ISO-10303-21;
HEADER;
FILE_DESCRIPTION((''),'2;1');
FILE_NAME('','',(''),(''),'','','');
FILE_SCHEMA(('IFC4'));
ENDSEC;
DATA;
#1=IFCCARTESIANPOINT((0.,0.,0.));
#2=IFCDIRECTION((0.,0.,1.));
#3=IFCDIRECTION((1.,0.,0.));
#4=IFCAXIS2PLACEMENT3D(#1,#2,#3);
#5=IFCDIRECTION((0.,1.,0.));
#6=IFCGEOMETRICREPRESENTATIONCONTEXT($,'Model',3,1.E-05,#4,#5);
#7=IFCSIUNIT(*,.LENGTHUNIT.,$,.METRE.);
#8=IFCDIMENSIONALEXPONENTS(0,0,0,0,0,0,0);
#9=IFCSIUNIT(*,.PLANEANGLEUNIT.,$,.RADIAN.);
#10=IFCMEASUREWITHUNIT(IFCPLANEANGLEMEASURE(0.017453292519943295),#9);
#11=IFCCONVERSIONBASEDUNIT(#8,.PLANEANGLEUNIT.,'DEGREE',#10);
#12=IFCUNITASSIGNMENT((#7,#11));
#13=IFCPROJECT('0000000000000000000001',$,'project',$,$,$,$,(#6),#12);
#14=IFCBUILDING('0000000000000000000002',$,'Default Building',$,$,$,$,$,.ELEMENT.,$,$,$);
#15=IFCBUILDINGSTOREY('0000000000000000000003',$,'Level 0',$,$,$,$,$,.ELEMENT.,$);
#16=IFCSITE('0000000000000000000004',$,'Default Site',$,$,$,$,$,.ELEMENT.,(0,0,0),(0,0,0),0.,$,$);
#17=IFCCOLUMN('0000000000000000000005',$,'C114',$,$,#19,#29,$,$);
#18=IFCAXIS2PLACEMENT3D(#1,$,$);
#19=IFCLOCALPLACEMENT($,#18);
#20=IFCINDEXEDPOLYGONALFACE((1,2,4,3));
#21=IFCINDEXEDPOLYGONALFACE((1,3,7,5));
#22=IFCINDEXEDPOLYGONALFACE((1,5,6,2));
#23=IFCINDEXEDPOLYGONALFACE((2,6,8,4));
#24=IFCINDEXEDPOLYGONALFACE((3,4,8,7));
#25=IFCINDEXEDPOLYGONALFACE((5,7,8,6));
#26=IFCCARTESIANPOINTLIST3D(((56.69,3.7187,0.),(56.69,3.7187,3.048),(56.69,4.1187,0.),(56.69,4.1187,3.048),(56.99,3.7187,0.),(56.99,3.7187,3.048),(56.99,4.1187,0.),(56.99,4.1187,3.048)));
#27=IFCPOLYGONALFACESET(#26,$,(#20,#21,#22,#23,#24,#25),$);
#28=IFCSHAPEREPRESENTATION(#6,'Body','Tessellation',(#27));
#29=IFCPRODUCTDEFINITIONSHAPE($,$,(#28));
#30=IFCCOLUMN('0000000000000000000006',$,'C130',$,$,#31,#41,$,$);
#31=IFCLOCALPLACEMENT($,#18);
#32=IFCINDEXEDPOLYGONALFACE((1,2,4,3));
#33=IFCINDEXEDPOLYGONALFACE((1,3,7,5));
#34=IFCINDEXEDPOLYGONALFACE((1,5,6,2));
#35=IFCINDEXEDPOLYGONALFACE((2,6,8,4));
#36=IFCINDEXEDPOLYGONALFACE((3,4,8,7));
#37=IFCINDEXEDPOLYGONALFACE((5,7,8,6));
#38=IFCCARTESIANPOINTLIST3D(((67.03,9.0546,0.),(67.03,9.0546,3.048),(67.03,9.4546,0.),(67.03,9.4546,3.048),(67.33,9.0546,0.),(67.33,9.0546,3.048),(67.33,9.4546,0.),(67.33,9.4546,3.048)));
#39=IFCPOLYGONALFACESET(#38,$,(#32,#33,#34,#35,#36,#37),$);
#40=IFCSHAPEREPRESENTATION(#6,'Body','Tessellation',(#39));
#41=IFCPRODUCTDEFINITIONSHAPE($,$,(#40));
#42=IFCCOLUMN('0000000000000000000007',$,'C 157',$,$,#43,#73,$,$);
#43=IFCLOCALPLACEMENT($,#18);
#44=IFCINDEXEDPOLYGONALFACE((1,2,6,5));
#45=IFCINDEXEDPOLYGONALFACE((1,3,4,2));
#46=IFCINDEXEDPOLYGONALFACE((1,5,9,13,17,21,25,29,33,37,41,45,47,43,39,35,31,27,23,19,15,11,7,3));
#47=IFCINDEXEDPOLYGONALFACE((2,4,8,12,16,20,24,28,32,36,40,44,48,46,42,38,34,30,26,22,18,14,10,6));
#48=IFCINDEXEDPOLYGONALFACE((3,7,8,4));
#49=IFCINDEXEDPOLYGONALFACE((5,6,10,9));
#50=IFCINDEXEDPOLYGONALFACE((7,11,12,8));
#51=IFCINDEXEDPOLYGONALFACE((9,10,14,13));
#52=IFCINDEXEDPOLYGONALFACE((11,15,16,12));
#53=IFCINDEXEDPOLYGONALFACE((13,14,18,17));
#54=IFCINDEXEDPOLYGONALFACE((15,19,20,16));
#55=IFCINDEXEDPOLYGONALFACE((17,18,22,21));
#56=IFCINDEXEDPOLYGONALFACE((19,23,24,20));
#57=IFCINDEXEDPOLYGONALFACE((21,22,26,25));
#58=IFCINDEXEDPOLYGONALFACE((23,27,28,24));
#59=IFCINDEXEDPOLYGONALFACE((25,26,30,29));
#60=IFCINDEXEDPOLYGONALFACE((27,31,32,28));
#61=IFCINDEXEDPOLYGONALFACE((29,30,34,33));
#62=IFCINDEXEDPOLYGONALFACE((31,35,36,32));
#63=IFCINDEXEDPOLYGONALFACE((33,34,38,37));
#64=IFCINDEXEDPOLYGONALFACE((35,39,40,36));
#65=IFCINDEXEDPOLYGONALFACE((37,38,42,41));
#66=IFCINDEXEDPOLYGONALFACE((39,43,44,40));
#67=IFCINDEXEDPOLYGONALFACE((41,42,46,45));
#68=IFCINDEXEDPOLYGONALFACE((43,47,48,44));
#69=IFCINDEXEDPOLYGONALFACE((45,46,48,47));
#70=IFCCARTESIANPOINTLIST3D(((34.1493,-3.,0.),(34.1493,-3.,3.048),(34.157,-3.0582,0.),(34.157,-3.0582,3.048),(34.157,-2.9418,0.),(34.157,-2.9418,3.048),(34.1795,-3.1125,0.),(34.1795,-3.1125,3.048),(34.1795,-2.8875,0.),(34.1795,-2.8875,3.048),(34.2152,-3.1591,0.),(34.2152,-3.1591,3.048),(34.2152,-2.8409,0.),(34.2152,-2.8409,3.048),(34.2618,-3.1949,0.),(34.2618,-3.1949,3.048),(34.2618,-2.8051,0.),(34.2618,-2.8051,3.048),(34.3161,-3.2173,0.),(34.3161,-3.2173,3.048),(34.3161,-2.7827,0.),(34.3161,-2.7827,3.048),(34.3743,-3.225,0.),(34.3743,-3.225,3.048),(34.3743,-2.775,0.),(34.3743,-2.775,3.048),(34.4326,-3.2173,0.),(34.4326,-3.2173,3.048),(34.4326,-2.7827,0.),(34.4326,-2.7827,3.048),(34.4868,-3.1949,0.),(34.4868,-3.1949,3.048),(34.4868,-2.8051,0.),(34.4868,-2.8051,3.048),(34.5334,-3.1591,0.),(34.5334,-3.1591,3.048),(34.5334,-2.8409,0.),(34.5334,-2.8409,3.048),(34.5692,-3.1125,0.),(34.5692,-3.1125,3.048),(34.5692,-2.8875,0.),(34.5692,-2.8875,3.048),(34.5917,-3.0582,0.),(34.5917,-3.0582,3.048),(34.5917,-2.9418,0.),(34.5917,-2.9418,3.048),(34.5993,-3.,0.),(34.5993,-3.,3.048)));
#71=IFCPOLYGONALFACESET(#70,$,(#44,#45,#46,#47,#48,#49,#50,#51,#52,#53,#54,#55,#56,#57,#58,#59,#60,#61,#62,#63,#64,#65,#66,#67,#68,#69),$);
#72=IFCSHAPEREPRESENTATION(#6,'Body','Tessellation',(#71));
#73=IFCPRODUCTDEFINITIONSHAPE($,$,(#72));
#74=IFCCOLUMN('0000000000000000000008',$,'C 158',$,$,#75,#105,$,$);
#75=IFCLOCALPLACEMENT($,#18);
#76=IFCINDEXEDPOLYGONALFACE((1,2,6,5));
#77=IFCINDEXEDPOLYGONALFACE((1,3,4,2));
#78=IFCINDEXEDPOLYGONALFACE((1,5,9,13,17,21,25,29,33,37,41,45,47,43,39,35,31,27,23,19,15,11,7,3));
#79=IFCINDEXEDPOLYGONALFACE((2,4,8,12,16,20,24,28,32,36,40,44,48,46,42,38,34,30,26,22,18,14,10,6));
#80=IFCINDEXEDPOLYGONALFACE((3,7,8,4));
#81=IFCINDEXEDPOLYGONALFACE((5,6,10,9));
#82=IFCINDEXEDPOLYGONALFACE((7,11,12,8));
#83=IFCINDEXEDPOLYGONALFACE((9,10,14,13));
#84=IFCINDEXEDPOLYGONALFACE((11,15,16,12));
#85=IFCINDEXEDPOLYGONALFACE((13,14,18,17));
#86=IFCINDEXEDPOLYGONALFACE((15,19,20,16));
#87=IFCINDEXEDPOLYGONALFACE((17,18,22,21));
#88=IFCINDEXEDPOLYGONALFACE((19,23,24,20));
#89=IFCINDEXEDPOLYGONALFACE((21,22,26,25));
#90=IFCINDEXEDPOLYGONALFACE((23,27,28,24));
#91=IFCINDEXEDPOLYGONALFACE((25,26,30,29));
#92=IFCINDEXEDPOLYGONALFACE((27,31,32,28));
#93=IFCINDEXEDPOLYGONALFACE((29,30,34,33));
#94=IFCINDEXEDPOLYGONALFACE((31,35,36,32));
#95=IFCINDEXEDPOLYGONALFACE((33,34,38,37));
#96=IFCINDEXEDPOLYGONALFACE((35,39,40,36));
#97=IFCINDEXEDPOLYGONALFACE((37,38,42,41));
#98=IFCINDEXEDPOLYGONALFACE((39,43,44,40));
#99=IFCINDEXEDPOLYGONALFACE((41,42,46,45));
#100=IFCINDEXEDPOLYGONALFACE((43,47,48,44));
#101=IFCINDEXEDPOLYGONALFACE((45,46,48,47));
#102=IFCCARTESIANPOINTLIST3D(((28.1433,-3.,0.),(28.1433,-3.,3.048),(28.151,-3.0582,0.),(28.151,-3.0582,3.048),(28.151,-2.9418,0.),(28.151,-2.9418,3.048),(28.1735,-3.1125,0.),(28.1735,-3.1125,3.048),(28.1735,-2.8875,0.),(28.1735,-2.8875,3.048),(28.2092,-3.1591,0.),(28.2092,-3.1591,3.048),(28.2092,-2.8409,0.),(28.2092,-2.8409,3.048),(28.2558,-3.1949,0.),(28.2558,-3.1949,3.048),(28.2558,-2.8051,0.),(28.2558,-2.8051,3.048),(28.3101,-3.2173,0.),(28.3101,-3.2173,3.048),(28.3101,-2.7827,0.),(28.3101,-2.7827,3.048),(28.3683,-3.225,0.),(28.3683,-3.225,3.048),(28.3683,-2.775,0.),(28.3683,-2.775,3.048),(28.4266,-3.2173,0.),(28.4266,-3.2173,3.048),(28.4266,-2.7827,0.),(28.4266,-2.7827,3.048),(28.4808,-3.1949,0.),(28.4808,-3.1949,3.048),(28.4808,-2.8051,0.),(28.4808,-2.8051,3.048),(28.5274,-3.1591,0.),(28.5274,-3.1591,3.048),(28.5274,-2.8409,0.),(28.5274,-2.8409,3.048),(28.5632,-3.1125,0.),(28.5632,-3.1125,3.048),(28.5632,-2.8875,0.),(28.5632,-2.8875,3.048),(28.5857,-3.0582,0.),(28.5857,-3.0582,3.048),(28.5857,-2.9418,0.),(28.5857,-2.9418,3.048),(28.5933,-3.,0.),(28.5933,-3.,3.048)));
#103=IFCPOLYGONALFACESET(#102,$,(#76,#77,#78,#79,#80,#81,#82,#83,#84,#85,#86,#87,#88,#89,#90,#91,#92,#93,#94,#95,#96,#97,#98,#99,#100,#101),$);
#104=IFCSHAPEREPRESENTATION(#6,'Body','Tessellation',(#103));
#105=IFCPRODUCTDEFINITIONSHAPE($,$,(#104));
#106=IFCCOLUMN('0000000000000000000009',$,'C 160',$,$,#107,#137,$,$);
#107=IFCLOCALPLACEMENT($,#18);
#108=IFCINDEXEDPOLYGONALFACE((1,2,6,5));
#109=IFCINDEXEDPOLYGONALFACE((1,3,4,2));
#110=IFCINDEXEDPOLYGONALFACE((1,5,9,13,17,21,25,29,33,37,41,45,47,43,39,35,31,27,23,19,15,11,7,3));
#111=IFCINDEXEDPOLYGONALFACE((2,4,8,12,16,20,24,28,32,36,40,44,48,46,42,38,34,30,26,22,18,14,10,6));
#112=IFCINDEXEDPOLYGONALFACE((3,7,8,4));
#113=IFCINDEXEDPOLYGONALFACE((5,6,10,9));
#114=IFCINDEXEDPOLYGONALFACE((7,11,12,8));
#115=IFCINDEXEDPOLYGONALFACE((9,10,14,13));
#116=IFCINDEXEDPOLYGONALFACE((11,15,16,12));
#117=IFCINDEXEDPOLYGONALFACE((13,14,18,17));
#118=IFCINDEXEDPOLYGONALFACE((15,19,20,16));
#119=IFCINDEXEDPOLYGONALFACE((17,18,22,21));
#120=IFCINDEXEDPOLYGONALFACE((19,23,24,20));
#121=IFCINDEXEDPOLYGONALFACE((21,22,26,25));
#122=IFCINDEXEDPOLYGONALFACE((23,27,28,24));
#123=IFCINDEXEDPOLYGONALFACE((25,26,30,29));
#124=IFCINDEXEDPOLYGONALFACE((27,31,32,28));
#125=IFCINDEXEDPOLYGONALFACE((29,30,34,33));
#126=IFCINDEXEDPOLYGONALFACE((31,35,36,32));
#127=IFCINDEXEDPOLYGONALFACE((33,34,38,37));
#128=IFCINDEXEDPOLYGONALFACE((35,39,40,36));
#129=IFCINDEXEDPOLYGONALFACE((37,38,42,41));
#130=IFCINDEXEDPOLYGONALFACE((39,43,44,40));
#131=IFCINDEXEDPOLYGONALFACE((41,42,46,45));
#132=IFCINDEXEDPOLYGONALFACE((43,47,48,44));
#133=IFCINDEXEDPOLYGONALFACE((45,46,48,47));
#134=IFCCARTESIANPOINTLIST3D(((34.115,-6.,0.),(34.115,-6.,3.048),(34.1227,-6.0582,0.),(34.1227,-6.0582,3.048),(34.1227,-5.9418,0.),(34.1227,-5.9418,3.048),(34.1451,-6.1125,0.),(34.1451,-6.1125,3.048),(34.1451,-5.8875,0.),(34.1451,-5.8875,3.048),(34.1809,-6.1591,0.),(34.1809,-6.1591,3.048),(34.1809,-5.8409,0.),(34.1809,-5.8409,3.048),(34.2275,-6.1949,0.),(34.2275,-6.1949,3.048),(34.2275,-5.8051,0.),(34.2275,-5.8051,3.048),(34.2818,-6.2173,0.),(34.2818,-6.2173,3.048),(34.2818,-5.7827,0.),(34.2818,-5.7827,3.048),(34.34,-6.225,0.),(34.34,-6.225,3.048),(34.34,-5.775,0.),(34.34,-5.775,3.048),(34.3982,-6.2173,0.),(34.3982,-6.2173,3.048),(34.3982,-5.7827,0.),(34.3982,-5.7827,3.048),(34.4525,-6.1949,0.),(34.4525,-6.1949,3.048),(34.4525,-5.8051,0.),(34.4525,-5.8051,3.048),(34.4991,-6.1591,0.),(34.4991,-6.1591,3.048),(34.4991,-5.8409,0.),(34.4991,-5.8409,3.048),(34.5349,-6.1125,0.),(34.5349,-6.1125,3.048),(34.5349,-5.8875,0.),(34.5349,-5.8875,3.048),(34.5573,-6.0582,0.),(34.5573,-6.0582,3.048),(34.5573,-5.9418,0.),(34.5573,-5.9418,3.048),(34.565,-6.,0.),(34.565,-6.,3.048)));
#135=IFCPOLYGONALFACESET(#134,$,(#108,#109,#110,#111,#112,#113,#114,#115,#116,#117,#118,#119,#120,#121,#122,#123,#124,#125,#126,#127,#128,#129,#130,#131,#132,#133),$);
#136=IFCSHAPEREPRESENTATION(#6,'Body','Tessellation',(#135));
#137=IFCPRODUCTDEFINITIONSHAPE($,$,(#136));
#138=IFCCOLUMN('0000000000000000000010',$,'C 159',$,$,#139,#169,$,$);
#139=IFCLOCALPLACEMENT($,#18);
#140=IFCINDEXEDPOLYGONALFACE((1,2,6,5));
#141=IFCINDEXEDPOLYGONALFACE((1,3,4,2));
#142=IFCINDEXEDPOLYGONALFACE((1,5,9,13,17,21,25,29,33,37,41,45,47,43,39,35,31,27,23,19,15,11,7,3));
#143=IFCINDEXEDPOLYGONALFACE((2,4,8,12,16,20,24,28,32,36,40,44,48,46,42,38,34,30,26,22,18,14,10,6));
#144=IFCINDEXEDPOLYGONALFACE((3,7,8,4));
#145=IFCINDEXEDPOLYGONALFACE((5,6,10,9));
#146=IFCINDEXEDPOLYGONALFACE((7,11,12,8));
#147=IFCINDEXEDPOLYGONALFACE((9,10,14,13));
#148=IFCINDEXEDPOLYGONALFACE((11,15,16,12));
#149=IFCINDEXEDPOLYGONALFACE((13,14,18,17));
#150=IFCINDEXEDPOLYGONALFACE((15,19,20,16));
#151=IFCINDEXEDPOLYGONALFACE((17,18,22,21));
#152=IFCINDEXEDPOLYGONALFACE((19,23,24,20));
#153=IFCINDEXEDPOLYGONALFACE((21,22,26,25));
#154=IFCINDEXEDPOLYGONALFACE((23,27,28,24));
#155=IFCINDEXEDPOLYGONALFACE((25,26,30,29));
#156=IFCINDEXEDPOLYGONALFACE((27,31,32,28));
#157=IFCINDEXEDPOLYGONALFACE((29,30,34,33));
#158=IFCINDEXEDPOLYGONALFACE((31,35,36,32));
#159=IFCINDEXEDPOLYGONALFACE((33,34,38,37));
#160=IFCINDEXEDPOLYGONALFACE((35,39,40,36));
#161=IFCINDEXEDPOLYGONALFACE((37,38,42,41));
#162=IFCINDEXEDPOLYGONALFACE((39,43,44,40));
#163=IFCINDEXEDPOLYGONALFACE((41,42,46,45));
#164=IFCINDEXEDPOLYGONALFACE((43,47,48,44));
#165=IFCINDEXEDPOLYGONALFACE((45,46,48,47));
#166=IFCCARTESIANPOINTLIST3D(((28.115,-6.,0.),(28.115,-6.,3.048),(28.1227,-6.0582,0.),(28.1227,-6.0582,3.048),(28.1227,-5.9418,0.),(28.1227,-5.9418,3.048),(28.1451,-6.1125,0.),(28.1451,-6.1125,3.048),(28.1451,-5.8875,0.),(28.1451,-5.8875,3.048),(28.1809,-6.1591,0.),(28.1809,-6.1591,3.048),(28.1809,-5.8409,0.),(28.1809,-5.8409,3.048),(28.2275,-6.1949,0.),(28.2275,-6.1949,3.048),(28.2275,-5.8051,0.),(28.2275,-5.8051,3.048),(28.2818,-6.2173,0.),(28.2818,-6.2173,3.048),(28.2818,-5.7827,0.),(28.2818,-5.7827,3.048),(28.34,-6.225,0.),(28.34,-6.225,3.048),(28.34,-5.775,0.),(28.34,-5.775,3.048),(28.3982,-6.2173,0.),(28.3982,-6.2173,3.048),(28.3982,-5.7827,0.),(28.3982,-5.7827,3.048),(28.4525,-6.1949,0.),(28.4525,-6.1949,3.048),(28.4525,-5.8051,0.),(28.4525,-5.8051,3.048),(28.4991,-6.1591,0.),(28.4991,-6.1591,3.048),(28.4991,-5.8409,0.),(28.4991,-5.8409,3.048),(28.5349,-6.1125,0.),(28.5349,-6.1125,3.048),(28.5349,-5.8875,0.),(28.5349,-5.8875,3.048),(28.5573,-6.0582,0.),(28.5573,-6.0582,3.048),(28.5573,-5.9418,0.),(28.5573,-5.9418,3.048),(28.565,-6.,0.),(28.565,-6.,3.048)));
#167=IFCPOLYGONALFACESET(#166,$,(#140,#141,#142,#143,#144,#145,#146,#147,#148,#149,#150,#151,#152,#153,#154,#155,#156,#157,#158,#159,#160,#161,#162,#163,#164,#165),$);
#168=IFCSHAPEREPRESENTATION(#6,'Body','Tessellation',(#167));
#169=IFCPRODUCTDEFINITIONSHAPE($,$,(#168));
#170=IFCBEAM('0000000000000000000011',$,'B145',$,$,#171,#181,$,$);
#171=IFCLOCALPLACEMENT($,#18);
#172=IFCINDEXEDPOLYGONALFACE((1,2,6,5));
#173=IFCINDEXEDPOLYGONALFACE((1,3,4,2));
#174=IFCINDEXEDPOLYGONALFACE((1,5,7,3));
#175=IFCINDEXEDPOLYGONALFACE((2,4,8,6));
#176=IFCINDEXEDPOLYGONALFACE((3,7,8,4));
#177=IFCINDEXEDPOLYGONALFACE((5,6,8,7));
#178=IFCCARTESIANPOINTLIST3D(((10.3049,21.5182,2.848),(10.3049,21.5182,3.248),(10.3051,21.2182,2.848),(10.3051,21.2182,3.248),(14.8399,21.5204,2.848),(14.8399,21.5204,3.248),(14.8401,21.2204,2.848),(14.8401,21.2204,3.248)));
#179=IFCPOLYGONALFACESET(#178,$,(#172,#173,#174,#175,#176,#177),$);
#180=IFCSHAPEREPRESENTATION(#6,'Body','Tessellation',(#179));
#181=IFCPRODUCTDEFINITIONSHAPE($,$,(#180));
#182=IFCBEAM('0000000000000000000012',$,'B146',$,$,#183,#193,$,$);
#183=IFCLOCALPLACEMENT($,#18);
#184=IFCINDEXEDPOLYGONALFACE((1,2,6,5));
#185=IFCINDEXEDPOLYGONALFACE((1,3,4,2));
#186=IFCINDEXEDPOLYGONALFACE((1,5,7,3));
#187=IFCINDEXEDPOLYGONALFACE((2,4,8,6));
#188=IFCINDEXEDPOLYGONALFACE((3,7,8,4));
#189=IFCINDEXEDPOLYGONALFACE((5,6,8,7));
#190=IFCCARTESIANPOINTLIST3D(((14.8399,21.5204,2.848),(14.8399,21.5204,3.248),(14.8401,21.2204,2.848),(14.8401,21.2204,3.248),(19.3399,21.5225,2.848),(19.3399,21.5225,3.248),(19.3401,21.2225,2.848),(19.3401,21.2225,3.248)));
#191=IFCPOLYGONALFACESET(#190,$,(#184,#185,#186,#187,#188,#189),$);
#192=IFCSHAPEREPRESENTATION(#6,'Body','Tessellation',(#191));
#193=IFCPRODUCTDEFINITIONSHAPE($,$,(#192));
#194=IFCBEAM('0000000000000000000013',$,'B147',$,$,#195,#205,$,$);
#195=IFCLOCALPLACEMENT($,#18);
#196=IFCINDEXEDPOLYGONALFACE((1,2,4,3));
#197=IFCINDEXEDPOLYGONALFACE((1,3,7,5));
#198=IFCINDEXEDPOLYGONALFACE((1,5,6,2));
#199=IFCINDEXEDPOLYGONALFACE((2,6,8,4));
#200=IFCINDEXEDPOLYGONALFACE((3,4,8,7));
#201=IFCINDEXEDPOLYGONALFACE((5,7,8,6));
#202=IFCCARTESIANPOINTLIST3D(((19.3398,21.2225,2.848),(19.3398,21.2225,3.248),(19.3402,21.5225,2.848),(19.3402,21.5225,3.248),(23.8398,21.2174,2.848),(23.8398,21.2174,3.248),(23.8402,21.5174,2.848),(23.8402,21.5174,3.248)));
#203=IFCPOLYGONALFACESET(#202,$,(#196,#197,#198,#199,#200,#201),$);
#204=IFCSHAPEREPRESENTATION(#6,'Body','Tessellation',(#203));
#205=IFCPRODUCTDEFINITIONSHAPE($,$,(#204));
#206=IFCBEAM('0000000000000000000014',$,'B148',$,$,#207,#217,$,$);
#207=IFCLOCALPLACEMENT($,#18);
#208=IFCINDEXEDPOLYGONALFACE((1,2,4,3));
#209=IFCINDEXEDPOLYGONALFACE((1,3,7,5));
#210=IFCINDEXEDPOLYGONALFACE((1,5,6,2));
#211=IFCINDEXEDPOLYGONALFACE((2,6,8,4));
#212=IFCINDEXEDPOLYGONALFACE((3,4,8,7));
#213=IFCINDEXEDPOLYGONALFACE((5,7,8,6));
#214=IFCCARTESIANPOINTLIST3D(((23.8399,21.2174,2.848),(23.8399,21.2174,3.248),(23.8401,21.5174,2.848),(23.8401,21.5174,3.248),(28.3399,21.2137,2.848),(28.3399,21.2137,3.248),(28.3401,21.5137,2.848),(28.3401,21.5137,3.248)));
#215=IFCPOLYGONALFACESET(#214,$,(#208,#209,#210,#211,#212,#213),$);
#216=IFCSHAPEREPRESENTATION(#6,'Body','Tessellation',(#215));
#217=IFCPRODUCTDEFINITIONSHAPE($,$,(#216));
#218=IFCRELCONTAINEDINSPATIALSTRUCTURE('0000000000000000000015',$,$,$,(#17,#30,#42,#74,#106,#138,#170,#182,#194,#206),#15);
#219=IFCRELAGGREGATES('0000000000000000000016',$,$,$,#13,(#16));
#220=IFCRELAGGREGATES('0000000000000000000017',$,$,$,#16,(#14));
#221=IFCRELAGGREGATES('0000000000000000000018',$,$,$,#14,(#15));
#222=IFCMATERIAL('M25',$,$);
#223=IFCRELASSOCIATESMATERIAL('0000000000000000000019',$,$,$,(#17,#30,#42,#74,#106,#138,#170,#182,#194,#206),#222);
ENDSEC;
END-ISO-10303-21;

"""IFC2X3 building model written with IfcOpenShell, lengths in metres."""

from ifc_helpers import new_model, entity, si_unit, converted_unit, direction, frame, frame_2d, origin_with_axes, origin_2d_with_axis, place, context, project, spatial, rectangle, circle, extrude, material, element, save


model = new_model("IFC2X3")

# Units and contexts
model_context = context("Model", 3, precision=1e-05, world=origin_with_axes(), true_north=direction((0.0, 1.0, 0.0)))
ifc_project = project(units=[si_unit("LENGTHUNIT", "METRE"), converted_unit("PLANEANGLEUNIT", "DEGREE", entity("IfcPlaneAngleMeasure", 0.017453292519943295), si_unit("PLANEANGLEUNIT", "RADIAN"), dimensions=[0, 0, 0, 0, 0, 0, 0])], contexts=[model_context])

# Site, building, storey
site = spatial("IfcSite", under=ifc_project, Name="Default Site", CompositionType="ELEMENT", RefLatitude=(0, 0, 0), RefLongitude=(0, 0, 0), RefElevation=0.0)
building = spatial("IfcBuilding", under=site, Name="Default Building", CompositionType="ELEMENT")
storey = spatial("IfcBuildingStorey", under=building, Name="Level 0", CompositionType="ELEMENT")

# Columns
ifc_material = material(Name="M25")
placement = place(None, origin_with_axes())
element("IfcColumn", 1, at=placement, inside=storey, material=ifc_material, Name="C114", context=model_context, shape_type="SweptSolid", body=[
    extrude(rectangle(XDim=0.3, YDim=0.4, at=frame_2d((0.0, 0.0), x_axis=(1.0, 0.0, 0.0))), frame((56.84, 3.9187, 0.0), z_axis=(0.0, 0.0, 1.0), x_axis=(1.0, 0.0, 0.0)), (0.0, 0.0, 1.0), 3.048),
])
element("IfcColumn", 2, at=placement, inside=storey, material=ifc_material, Name="C130", context=model_context, shape_type="SweptSolid", body=[
    extrude(rectangle(XDim=0.3, YDim=0.4, at=frame_2d((0.0, 0.0), x_axis=(1.0, 0.0, 0.0))), frame((67.18, 9.2546, 0.0), z_axis=(0.0, 0.0, 1.0), x_axis=(1.0, 0.0, 0.0)), (0.0, 0.0, 1.0), 3.048),
])
element("IfcColumn", 3, at=placement, inside=storey, material=ifc_material, Name="C 157", context=model_context, shape_type="SweptSolid", body=[
    extrude(circle(Radius=0.225, at=origin_2d_with_axis()), frame((34.3743, -3.0, 0.0), z_axis=(0.0, 0.0, 1.0), x_axis=(1.0, 0.0, 0.0)), (0.0, 0.0, 1.0), 3.048),
])
element("IfcColumn", 4, at=placement, inside=storey, material=ifc_material, Name="C 158", context=model_context, shape_type="SweptSolid", body=[
    extrude(circle(Radius=0.225, at=origin_2d_with_axis()), frame((28.3683, -3.0, 0.0), z_axis=(0.0, 0.0, 1.0), x_axis=(1.0, 0.0, 0.0)), (0.0, 0.0, 1.0), 3.048),
])
element("IfcColumn", 5, at=placement, inside=storey, material=ifc_material, Name="C 160", context=model_context, shape_type="SweptSolid", body=[
    extrude(circle(Radius=0.225, at=origin_2d_with_axis()), frame((34.34, -6.0, 0.0), z_axis=(0.0, 0.0, 1.0), x_axis=(1.0, 0.0, 0.0)), (0.0, 0.0, 1.0), 3.048),
])
element("IfcColumn", 6, at=placement, inside=storey, material=ifc_material, Name="C 159", context=model_context, shape_type="SweptSolid", body=[
    extrude(circle(Radius=0.225, at=origin_2d_with_axis()), frame((28.34, -6.0, 0.0), z_axis=(0.0, 0.0, 1.0), x_axis=(1.0, 0.0, 0.0)), (0.0, 0.0, 1.0), 3.048),
])

# Beams
element("IfcBeam", 7, at=placement, inside=storey, material=ifc_material, Name="B145", context=model_context, shape_type="SweptSolid", body=[
    extrude(rectangle(XDim=0.3, YDim=0.4, at=frame_2d((0.0, 0.0), x_axis=(0.0, 1.0, 0.0))), frame((10.305, 21.3682, 3.048), z_axis=(1.0, 0.000476, 0.0), x_axis=(0.0, 0.0, -1.0)), (0.0, 0.0, 1.0), 4.535),
])
element("IfcBeam", 8, at=placement, inside=storey, material=ifc_material, Name="B146", context=model_context, shape_type="SweptSolid", body=[
    extrude(rectangle(XDim=0.3, YDim=0.4, at=frame_2d((0.0, 0.0), x_axis=(0.0, 1.0, 0.0))), frame((14.84, 21.3704, 3.048), z_axis=(1.0, 0.000471, 0.0), x_axis=(0.0, 0.0, -1.0)), (0.0, 0.0, 1.0), 4.5),
])
element("IfcBeam", 9, at=placement, inside=storey, material=ifc_material, Name="B147", context=model_context, shape_type="SweptSolid", body=[
    extrude(rectangle(XDim=0.3, YDim=0.4, at=frame_2d((0.0, 0.0), x_axis=(0.0, 1.0, 0.0))), frame((19.34, 21.3725, 3.048), z_axis=(0.999999, -0.001141, 0.0), x_axis=(0.0, 0.0, -1.0)), (0.0, 0.0, 1.0), 4.5),
])
element("IfcBeam", 10, at=placement, inside=storey, material=ifc_material, Name="B148", context=model_context, shape_type="SweptSolid", body=[
    extrude(rectangle(XDim=0.3, YDim=0.4, at=frame_2d((0.0, 0.0), x_axis=(0.0, 1.0, 0.0))), frame((23.84, 21.3674, 3.048), z_axis=(1.0, -0.000812, 0.0), x_axis=(0.0, 0.0, -1.0)), (0.0, 0.0, 1.0), 4.5),
])

save(model, "model.ifc")
